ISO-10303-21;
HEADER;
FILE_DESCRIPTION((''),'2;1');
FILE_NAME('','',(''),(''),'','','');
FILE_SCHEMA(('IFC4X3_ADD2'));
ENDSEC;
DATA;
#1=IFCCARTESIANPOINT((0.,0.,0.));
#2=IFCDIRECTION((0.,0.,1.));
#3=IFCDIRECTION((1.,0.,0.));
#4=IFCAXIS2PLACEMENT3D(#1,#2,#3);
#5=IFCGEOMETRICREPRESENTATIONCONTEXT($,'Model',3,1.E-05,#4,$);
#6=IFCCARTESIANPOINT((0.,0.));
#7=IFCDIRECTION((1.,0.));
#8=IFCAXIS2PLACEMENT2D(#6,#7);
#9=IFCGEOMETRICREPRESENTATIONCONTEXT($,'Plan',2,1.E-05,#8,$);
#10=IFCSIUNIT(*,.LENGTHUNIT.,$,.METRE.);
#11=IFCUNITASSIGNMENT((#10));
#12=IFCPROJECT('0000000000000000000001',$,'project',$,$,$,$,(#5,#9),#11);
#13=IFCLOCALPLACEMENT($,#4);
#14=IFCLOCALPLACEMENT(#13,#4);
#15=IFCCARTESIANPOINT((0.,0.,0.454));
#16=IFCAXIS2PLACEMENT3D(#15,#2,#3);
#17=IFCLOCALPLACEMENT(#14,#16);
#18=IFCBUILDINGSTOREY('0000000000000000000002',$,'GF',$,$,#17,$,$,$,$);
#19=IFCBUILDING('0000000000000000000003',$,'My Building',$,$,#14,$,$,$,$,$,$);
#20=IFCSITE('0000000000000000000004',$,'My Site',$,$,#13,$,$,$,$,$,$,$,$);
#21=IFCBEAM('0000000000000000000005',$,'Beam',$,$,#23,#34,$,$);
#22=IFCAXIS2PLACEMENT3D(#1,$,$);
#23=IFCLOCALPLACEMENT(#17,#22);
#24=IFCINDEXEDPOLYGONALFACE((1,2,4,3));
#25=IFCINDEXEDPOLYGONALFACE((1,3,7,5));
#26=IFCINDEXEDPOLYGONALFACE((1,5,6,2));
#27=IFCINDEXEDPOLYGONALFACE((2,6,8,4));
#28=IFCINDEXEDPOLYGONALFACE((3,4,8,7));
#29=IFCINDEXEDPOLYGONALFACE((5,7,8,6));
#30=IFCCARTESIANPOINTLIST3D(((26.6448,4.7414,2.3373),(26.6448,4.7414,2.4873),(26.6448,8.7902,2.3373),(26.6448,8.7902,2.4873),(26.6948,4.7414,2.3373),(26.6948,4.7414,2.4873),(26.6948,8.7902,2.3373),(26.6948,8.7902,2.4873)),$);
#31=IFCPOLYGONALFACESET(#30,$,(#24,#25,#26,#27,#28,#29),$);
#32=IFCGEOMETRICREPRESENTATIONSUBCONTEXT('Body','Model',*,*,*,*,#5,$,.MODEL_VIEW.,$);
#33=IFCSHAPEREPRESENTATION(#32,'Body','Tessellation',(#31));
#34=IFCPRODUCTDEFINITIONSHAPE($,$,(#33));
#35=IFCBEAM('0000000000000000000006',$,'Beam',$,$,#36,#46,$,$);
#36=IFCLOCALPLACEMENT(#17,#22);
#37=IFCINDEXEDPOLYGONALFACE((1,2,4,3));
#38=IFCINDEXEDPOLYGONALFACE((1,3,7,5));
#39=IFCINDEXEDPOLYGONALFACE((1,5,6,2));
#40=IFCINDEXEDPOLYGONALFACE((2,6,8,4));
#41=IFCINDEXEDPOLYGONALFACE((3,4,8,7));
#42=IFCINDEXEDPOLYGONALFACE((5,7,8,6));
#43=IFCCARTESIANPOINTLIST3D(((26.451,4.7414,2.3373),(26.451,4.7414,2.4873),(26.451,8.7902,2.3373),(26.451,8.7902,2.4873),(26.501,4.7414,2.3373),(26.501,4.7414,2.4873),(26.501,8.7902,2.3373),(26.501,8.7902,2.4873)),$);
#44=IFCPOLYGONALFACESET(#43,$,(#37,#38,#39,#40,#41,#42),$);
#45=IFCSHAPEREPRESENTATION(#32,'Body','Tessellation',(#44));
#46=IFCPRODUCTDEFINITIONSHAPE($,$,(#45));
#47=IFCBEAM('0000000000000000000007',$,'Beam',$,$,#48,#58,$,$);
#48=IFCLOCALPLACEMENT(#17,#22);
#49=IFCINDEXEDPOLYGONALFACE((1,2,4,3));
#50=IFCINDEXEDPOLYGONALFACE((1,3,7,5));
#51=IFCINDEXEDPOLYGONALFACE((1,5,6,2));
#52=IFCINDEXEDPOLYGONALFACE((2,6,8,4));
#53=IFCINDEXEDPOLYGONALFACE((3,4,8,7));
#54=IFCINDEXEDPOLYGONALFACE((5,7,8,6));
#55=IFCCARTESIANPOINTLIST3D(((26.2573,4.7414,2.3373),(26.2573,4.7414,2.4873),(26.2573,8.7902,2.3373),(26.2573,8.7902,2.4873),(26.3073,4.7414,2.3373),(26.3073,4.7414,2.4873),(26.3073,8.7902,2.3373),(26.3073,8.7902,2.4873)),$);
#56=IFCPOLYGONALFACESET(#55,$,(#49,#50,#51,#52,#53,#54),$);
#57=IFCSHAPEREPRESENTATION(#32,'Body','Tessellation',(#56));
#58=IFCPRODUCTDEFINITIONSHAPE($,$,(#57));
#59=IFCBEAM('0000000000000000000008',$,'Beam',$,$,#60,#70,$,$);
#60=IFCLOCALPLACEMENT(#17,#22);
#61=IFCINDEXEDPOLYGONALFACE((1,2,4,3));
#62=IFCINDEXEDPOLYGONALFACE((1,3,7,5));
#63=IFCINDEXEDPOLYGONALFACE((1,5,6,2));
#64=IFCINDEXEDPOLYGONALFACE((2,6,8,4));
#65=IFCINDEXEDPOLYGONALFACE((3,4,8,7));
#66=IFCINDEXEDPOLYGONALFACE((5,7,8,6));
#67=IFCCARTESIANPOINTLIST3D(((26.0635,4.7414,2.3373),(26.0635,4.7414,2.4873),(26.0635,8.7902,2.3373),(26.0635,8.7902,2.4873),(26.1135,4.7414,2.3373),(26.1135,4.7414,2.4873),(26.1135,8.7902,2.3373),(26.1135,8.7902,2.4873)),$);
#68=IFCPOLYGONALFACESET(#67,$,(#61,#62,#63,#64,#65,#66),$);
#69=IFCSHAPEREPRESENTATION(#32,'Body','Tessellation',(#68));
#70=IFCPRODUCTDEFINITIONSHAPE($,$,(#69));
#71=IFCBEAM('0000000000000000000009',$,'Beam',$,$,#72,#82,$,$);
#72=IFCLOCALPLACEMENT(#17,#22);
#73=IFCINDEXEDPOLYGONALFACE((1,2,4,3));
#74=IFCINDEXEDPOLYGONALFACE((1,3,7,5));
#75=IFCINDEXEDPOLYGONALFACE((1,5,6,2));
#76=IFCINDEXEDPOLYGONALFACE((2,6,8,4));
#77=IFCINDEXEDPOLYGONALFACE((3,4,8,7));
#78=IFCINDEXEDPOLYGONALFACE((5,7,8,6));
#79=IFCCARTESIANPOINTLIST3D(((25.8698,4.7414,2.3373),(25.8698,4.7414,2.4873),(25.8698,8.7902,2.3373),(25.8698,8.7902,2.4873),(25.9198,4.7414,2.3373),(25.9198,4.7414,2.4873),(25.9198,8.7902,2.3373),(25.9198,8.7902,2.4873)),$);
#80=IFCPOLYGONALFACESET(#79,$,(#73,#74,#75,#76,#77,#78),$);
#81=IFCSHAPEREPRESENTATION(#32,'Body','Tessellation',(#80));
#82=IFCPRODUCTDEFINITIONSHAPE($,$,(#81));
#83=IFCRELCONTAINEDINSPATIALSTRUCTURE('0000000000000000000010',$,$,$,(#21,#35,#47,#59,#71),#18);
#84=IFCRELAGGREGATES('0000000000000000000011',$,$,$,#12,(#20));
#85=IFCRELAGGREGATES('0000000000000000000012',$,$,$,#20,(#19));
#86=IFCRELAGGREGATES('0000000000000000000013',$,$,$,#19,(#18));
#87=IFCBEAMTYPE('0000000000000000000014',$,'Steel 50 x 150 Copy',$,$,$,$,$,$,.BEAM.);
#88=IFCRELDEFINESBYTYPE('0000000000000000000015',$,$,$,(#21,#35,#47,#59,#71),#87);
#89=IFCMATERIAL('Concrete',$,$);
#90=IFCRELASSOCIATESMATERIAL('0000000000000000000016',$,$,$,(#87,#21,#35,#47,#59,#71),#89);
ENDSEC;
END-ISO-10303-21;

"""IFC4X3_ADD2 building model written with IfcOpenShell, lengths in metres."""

from ifc_helpers import new_model, si_unit, frame, origin_with_axes, origin_2d_with_axis, place, context, subcontext, project, spatial, rectangle, extrude, material, material_profile, profile_set, profile_usage, type_object, element, save


model = new_model("IFC4X3_ADD2")

# Units and contexts
model_context = context("Model", 3, precision=1e-05, world=origin_with_axes())
plan_context = context("Plan", 2, precision=1e-05, world=origin_2d_with_axis())
body_context_1 = subcontext(model_context, "Body", "Model", "MODEL_VIEW")
ifc_project = project(units=[si_unit("LENGTHUNIT", "METRE")], contexts=[model_context, plan_context])

# Site, building, storey
site_placement = place(None, origin_with_axes())
site = spatial("IfcSite", under=ifc_project, at=site_placement, Name="My Site")
building_placement = place(site_placement, origin_with_axes())
building = spatial("IfcBuilding", under=site, at=building_placement, Name="My Building")
storey_placement = place(building_placement, frame((0.0, 0.0, 0.454), z_axis=(0.0, 0.0, 1.0), x_axis=(1.0, 0.0, 0.0)))
storey = spatial("IfcBuildingStorey", under=building, at=storey_placement, Name="GF")

# Beams
ifc_material_1 = material(Name="Concrete")
ifc_material_profile = material_profile(ifc_material_1, rectangle(XDim=0.05, YDim=0.15))
ifc_profile_set = profile_set([ifc_material_profile])
ifc_profile_usage_1 = profile_usage(ifc_profile_set)
beam_type = type_object("IfcBeamType", Name="Steel 50 x 150 Copy", PredefinedType="BEAM", material=ifc_profile_set)
beam_1_placement = place(storey_placement, frame((26.6698, 8.7902, 2.4123), z_axis=(0.0, -1.0, 0.0), x_axis=(1.0, 0.0, 0.0)))
element("IfcBeam", 1, at=beam_1_placement, inside=storey, type_object=beam_type, material=ifc_profile_usage_1, Name="Beam", context=body_context_1, shape_type="SweptSolid", body=[
    extrude(rectangle(XDim=0.05, YDim=0.15), origin_with_axes(), (0.0, 0.0, 1.0), 4.0488),
])
ifc_profile_usage_2 = profile_usage(ifc_profile_set)
beam_2_placement = place(storey_placement, frame((26.476, 8.7902, 2.4123), z_axis=(0.0, -1.0, 0.0), x_axis=(1.0, 0.0, 0.0)))
element("IfcBeam", 2, at=beam_2_placement, inside=storey, type_object=beam_type, material=ifc_profile_usage_2, Name="Beam", context=body_context_1, shape_type="SweptSolid", body=[
    extrude(rectangle(XDim=0.05, YDim=0.15), origin_with_axes(), (0.0, 0.0, 1.0), 4.0488),
])
ifc_profile_usage_3 = profile_usage(ifc_profile_set)
beam_3_placement = place(storey_placement, frame((26.2823, 8.7902, 2.4123), z_axis=(0.0, -1.0, 0.0), x_axis=(1.0, 0.0, 0.0)))
element("IfcBeam", 3, at=beam_3_placement, inside=storey, type_object=beam_type, material=ifc_profile_usage_3, Name="Beam", context=body_context_1, shape_type="SweptSolid", body=[
    extrude(rectangle(XDim=0.05, YDim=0.15), origin_with_axes(), (0.0, 0.0, 1.0), 4.0488),
])
ifc_profile_usage_4 = profile_usage(ifc_profile_set)
beam_4_placement = place(storey_placement, frame((26.0885, 8.7902, 2.4123), z_axis=(0.0, -1.0, 0.0), x_axis=(1.0, 0.0, 0.0)))
element("IfcBeam", 4, at=beam_4_placement, inside=storey, type_object=beam_type, material=ifc_profile_usage_4, Name="Beam", context=body_context_1, shape_type="SweptSolid", body=[
    extrude(rectangle(XDim=0.05, YDim=0.15), origin_with_axes(), (0.0, 0.0, 1.0), 4.0488),
])
ifc_profile_usage_5 = profile_usage(ifc_profile_set)
beam_5_placement = place(storey_placement, frame((25.8948, 8.7902, 2.4123), z_axis=(0.0, -1.0, 0.0), x_axis=(1.0, 0.0, 0.0)))
element("IfcBeam", 5, at=beam_5_placement, inside=storey, type_object=beam_type, material=ifc_profile_usage_5, Name="Beam", context=body_context_1, shape_type="SweptSolid", body=[
    extrude(rectangle(XDim=0.05, YDim=0.15), origin_with_axes(), (0.0, 0.0, 1.0), 4.0488),
])

save(model, "model.ifc")
